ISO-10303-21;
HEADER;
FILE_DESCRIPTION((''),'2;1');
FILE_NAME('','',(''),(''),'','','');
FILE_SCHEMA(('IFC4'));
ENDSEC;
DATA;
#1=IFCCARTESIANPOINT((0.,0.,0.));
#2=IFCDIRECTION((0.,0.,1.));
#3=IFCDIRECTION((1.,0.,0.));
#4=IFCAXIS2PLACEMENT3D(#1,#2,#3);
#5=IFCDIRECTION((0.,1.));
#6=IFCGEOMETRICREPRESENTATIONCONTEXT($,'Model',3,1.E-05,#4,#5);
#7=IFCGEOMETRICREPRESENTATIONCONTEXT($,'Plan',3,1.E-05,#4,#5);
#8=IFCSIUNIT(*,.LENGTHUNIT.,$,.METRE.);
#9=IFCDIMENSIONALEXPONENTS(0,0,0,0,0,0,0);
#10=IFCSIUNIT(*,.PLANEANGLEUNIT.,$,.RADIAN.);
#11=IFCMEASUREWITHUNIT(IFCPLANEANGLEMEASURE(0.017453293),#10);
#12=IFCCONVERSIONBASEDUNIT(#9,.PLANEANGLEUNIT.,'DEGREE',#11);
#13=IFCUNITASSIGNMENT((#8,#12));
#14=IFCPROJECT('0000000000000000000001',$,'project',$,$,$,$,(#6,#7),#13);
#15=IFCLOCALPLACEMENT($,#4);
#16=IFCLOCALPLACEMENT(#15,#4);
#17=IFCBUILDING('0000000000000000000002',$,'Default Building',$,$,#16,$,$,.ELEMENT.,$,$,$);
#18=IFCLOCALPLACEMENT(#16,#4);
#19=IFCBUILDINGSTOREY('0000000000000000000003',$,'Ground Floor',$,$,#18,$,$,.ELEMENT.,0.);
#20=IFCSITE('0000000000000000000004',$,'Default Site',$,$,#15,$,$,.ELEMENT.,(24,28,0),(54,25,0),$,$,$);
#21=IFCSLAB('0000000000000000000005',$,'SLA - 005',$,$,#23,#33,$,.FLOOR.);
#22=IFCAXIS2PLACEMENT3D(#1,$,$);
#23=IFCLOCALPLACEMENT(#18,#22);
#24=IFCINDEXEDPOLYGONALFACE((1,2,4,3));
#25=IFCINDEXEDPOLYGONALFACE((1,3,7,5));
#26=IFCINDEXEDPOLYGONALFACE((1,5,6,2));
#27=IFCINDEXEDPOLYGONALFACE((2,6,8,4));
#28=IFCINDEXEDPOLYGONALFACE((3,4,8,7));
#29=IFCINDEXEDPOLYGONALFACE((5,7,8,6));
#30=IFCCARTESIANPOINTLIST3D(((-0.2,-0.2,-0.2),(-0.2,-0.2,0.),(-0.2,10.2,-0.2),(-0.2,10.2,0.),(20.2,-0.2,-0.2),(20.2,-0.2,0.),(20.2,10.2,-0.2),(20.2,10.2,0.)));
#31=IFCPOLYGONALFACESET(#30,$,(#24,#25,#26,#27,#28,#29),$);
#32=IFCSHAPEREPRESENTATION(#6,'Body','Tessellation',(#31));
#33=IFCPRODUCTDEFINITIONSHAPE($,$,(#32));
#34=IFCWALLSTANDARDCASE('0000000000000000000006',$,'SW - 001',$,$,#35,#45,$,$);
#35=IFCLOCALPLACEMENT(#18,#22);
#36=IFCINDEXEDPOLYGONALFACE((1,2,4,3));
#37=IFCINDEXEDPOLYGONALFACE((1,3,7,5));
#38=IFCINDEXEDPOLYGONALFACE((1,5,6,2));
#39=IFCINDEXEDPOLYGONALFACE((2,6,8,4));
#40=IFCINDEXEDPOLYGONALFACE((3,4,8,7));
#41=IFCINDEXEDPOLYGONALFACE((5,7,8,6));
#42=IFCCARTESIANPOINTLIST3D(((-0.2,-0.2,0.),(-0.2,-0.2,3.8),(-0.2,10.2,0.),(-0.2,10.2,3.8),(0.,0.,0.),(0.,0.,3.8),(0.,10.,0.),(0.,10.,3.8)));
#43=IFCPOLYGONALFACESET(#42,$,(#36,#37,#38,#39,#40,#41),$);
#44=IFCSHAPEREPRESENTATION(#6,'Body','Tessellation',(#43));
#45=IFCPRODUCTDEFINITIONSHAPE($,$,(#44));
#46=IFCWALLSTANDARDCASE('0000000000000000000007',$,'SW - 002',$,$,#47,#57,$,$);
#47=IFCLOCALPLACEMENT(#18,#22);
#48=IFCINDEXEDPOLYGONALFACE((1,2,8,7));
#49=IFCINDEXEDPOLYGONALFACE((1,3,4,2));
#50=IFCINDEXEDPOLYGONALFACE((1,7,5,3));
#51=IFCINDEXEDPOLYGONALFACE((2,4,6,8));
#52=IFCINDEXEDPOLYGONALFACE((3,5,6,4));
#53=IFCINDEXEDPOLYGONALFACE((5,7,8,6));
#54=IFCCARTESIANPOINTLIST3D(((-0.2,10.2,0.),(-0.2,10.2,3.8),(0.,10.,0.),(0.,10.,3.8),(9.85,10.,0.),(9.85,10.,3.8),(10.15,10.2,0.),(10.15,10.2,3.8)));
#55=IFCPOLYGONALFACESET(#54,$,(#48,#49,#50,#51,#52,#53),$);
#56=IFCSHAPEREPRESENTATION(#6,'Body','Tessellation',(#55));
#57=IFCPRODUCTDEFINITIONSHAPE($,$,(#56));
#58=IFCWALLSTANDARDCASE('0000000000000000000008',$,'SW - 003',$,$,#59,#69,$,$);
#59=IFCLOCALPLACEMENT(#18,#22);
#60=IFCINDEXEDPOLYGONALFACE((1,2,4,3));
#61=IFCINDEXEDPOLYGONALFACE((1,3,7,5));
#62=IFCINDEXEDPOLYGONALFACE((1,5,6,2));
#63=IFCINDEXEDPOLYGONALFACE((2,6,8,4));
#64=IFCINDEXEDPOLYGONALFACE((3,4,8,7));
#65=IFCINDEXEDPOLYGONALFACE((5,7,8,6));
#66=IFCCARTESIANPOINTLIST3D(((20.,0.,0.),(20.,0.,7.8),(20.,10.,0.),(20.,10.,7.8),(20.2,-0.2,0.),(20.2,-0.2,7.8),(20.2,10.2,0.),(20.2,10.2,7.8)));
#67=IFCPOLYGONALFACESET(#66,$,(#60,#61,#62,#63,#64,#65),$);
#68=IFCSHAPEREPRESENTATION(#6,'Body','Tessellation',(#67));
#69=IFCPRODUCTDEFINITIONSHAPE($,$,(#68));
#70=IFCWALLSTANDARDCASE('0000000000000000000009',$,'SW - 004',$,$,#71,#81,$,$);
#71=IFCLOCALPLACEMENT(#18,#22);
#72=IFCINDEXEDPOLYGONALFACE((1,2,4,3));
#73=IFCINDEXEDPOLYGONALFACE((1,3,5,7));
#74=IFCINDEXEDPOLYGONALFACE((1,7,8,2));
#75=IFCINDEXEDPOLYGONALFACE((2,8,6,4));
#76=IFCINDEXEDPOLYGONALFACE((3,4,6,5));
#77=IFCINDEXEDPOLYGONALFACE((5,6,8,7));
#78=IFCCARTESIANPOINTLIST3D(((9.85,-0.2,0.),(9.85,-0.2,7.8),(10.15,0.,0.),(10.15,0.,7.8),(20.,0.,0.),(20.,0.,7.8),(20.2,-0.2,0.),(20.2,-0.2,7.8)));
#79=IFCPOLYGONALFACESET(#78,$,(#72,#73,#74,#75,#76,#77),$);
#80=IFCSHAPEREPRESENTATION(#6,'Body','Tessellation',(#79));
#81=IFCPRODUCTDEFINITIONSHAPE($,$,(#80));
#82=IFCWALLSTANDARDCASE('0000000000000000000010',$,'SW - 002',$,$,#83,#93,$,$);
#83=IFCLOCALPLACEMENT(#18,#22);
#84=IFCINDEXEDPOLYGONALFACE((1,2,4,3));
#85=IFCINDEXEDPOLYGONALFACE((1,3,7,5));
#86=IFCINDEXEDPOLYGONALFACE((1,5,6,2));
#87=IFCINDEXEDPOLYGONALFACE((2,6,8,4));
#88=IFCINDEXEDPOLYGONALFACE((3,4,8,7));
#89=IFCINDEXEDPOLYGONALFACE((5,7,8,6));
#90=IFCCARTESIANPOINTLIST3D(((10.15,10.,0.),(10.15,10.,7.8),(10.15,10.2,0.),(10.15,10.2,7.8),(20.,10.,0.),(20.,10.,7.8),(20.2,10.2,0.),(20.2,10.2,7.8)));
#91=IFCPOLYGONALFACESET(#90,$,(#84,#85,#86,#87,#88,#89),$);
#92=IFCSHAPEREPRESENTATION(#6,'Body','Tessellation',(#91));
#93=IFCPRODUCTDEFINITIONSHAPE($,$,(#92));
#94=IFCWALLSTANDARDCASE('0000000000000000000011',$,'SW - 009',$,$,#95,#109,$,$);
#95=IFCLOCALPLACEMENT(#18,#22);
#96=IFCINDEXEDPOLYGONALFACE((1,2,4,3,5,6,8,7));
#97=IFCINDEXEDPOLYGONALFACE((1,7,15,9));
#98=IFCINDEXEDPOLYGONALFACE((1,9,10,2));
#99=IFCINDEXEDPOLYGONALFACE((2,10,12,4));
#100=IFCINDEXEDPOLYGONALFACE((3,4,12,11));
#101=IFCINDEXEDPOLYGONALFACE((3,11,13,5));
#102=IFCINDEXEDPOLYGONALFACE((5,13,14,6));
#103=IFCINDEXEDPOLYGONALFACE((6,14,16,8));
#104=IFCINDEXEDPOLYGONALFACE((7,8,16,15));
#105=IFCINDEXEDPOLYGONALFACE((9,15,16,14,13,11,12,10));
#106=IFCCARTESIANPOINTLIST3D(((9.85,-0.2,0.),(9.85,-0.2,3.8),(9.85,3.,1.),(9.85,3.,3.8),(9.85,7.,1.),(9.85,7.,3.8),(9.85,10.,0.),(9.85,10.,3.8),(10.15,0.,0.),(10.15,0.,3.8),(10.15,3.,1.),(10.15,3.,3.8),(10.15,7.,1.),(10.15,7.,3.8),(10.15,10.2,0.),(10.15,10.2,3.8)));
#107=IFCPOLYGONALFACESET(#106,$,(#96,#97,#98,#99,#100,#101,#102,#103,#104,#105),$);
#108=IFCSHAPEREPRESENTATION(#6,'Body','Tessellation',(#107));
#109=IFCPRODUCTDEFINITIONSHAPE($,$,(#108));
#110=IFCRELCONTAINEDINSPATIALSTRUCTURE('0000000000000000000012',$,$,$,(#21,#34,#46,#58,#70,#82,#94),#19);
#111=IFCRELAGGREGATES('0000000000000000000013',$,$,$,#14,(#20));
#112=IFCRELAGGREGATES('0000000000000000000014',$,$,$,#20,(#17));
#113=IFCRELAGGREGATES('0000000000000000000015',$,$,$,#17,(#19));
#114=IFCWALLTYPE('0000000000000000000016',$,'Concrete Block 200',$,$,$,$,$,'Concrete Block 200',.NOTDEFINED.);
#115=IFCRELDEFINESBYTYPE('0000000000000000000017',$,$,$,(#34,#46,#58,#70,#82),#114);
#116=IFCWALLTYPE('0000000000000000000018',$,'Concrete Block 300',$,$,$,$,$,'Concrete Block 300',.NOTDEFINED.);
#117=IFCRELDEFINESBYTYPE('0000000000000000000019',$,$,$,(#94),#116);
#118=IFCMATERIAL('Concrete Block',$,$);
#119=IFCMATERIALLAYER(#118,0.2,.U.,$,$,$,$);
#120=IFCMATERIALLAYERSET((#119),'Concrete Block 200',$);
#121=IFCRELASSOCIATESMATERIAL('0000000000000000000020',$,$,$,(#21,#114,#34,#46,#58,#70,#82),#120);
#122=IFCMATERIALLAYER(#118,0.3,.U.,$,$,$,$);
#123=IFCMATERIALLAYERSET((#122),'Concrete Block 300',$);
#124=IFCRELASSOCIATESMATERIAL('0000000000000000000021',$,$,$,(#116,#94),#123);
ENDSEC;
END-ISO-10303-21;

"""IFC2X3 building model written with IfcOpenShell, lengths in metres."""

from ifc_helpers import new_model, entity, si_unit, converted_unit, direction, frame, frame_2d, origin_with_axes, place, context, project, spatial, polyline, rectangle, outline, extrude, material, layer, layer_set, layer_usage, type_object, element, save


model = new_model("IFC2X3")

# Units and contexts
model_context = context("Model", 3, precision=1e-05, world=origin_with_axes(), true_north=direction((0.0, 1.0)))
plan_context = context("Plan", 3, precision=1e-05, world=origin_with_axes(), true_north=direction((0.0, 1.0)))
ifc_project = project(units=[si_unit("LENGTHUNIT", "METRE"), converted_unit("PLANEANGLEUNIT", "DEGREE", entity("IfcPlaneAngleMeasure", 0.017453293), si_unit("PLANEANGLEUNIT", "RADIAN"), dimensions=[0, 0, 0, 0, 0, 0, 0])], contexts=[model_context, plan_context])

# Site, building, storey
site_placement = place(None, origin_with_axes())
site = spatial("IfcSite", under=ifc_project, at=site_placement, Name="Default Site", CompositionType="ELEMENT", RefLatitude=(24, 28, 0), RefLongitude=(54, 25, 0))
building_placement = place(site_placement, origin_with_axes())
building = spatial("IfcBuilding", under=site, at=building_placement, Name="Default Building", CompositionType="ELEMENT")
storey_placement = place(building_placement, origin_with_axes())
storey = spatial("IfcBuildingStorey", under=building, at=storey_placement, Name="Ground Floor", CompositionType="ELEMENT", Elevation=0.0)

# Slab
ifc_material = material(Name="Concrete Block")
ifc_layer_1 = layer(ifc_material, 0.2, ventilated="UNKNOWN")
ifc_layer_set_1 = layer_set([ifc_layer_1], Name="Concrete Block 200")
ifc_layer_usage_1 = layer_usage(ifc_layer_set_1, "AXIS3", "NEGATIVE", 0.2)
slab_placement = place(storey_placement, frame((-0.2, 10.2, -0.2), z_axis=(0.0, 0.0, 1.0), x_axis=(1.0, 0.0, 0.0)))
element("IfcSlab", 1, at=slab_placement, inside=storey, material=ifc_layer_usage_1, Name="SLA - 005", PredefinedType="FLOOR", context=model_context, shape_type="SweptSolid", body=[
    extrude(outline(polyline([(0.0, 0.0), (20.4, 0.0), (20.4, -10.4), (0.0, -10.4), (0.0, 0.0)])), origin_with_axes(), (0.0, 0.0, 1.0), 0.2),
])

# Walls
ifc_layer_usage_2 = layer_usage(ifc_layer_set_1, "AXIS2", "POSITIVE", 0.0)
wall_type_1 = type_object("IfcWallType", Name="Concrete Block 200", ElementType="Concrete Block 200", PredefinedType="NOTDEFINED", material=ifc_layer_set_1)
wall_1_placement = place(storey_placement, frame((0.0, 0.0, 0.0), z_axis=(0.0, 0.0, 1.0), x_axis=(0.0, 1.0, 0.0)))
element("IfcWallStandardCase", 2, at=wall_1_placement, inside=storey, type_object=wall_type_1, material=ifc_layer_usage_2, Name="SW - 001", context=model_context, shape_type="SweptSolid", body=[
    extrude(outline(polyline([(0.0, 0.0), (10.0, 0.0), (10.2, 0.2), (-0.2, 0.2), (0.0, 0.0)])), origin_with_axes(), (0.0, 0.0, 1.0), 3.8),
])
ifc_layer_usage_3 = layer_usage(ifc_layer_set_1, "AXIS2", "POSITIVE", 0.0)
wall_2_placement = place(storey_placement, frame((0.0, 10.0, 0.0), z_axis=(0.0, 0.0, 1.0), x_axis=(1.0, 0.0, 0.0)))
element("IfcWallStandardCase", 3, at=wall_2_placement, inside=storey, type_object=wall_type_1, material=ifc_layer_usage_3, Name="SW - 002", context=model_context, shape_type="SweptSolid", body=[
    extrude(outline(polyline([(0.0, 0.0), (9.85, 0.0), (10.15, 0.2), (-0.2, 0.2), (0.0, 0.0)])), origin_with_axes(), (0.0, 0.0, 1.0), 3.8),
])
ifc_layer_usage_4 = layer_usage(ifc_layer_set_1, "AXIS2", "POSITIVE", 0.0)
wall_3_placement = place(storey_placement, frame((20.0, 10.0, 0.0), z_axis=(0.0, 0.0, 1.0), x_axis=(0.0, -1.0, 0.0)))
element("IfcWallStandardCase", 4, at=wall_3_placement, inside=storey, type_object=wall_type_1, material=ifc_layer_usage_4, Name="SW - 003", context=model_context, shape_type="SweptSolid", body=[
    extrude(outline(polyline([(0.0, 0.0), (10.0, 0.0), (10.2, 0.2), (-0.2, 0.2), (0.0, 0.0)])), origin_with_axes(), (0.0, 0.0, 1.0), 7.8),
])
ifc_layer_usage_5 = layer_usage(ifc_layer_set_1, "AXIS2", "POSITIVE", 0.0)
wall_4_placement = place(storey_placement, frame((20.0, 0.0, 0.0), z_axis=(0.0, 0.0, 1.0), x_axis=(-1.0, 0.0, 0.0)))
element("IfcWallStandardCase", 5, at=wall_4_placement, inside=storey, type_object=wall_type_1, material=ifc_layer_usage_5, Name="SW - 004", context=model_context, shape_type="SweptSolid", body=[
    extrude(outline(polyline([(0.0, 0.0), (9.85, 0.0), (10.15, 0.2), (-0.2, 0.2), (0.0, 0.0)])), origin_with_axes(), (0.0, 0.0, 1.0), 7.8),
])
ifc_layer_usage_6 = layer_usage(ifc_layer_set_1, "AXIS2", "POSITIVE", 0.0)
wall_5_placement = place(storey_placement, frame((10.15, 10.0, 0.0), z_axis=(0.0, 0.0, 1.0), x_axis=(1.0, 0.0, 0.0)))
element("IfcWallStandardCase", 6, at=wall_5_placement, inside=storey, type_object=wall_type_1, material=ifc_layer_usage_6, Name="SW - 002", context=model_context, shape_type="SweptSolid", body=[
    extrude(outline(polyline([(0.0, 0.0), (9.85, 0.0), (10.05, 0.2), (0.0, 0.2), (0.0, 0.0)])), origin_with_axes(), (0.0, 0.0, 1.0), 7.8),
])

# Wall, opening
ifc_layer_2 = layer(ifc_material, 0.3, ventilated="UNKNOWN")
ifc_layer_set_2 = layer_set([ifc_layer_2], Name="Concrete Block 300")
ifc_layer_usage_7 = layer_usage(ifc_layer_set_2, "AXIS2", "POSITIVE", 0.0)
wall_type_2 = type_object("IfcWallType", Name="Concrete Block 300", ElementType="Concrete Block 300", PredefinedType="NOTDEFINED", material=ifc_layer_set_2)
wall_6_placement = place(storey_placement, frame((10.15, 0.0, 0.0), z_axis=(0.0, 0.0, 1.0), x_axis=(0.0, 1.0, 0.0)))
wall_6 = element("IfcWallStandardCase", 7, at=wall_6_placement, inside=storey, type_object=wall_type_2, material=ifc_layer_usage_7, Name="SW - 009", context=model_context, shape_type="SweptSolid", body=[
    extrude(outline(polyline([(0.0, 0.0), (10.2, 0.0), (10.0, 0.3), (-0.2, 0.3), (0.0, 0.0)])), origin_with_axes(), (0.0, 0.0, 1.0), 3.8),
])
opening_placement = place(wall_6_placement, frame((5.0, 0.0, 1.0), z_axis=(0.0, 0.0, 1.0), x_axis=(1.0, 0.0, 0.0)))
element("IfcOpeningElement", 8, at=opening_placement, cuts=wall_6, ObjectType="Opening", context=model_context, shape_type="SweptSolid", body=[
    extrude(rectangle(XDim=4.0, YDim=2.8, at=frame_2d((0.0, 1.4), x_axis=(1.0, 0.0))), frame((0.0, 0.0, 0.0), z_axis=(0.0, 1.0, 0.0), x_axis=(-1.0, 0.0, 0.0)), (0.0, 0.0, 1.0), 0.3),
])

save(model, "model.ifc")
